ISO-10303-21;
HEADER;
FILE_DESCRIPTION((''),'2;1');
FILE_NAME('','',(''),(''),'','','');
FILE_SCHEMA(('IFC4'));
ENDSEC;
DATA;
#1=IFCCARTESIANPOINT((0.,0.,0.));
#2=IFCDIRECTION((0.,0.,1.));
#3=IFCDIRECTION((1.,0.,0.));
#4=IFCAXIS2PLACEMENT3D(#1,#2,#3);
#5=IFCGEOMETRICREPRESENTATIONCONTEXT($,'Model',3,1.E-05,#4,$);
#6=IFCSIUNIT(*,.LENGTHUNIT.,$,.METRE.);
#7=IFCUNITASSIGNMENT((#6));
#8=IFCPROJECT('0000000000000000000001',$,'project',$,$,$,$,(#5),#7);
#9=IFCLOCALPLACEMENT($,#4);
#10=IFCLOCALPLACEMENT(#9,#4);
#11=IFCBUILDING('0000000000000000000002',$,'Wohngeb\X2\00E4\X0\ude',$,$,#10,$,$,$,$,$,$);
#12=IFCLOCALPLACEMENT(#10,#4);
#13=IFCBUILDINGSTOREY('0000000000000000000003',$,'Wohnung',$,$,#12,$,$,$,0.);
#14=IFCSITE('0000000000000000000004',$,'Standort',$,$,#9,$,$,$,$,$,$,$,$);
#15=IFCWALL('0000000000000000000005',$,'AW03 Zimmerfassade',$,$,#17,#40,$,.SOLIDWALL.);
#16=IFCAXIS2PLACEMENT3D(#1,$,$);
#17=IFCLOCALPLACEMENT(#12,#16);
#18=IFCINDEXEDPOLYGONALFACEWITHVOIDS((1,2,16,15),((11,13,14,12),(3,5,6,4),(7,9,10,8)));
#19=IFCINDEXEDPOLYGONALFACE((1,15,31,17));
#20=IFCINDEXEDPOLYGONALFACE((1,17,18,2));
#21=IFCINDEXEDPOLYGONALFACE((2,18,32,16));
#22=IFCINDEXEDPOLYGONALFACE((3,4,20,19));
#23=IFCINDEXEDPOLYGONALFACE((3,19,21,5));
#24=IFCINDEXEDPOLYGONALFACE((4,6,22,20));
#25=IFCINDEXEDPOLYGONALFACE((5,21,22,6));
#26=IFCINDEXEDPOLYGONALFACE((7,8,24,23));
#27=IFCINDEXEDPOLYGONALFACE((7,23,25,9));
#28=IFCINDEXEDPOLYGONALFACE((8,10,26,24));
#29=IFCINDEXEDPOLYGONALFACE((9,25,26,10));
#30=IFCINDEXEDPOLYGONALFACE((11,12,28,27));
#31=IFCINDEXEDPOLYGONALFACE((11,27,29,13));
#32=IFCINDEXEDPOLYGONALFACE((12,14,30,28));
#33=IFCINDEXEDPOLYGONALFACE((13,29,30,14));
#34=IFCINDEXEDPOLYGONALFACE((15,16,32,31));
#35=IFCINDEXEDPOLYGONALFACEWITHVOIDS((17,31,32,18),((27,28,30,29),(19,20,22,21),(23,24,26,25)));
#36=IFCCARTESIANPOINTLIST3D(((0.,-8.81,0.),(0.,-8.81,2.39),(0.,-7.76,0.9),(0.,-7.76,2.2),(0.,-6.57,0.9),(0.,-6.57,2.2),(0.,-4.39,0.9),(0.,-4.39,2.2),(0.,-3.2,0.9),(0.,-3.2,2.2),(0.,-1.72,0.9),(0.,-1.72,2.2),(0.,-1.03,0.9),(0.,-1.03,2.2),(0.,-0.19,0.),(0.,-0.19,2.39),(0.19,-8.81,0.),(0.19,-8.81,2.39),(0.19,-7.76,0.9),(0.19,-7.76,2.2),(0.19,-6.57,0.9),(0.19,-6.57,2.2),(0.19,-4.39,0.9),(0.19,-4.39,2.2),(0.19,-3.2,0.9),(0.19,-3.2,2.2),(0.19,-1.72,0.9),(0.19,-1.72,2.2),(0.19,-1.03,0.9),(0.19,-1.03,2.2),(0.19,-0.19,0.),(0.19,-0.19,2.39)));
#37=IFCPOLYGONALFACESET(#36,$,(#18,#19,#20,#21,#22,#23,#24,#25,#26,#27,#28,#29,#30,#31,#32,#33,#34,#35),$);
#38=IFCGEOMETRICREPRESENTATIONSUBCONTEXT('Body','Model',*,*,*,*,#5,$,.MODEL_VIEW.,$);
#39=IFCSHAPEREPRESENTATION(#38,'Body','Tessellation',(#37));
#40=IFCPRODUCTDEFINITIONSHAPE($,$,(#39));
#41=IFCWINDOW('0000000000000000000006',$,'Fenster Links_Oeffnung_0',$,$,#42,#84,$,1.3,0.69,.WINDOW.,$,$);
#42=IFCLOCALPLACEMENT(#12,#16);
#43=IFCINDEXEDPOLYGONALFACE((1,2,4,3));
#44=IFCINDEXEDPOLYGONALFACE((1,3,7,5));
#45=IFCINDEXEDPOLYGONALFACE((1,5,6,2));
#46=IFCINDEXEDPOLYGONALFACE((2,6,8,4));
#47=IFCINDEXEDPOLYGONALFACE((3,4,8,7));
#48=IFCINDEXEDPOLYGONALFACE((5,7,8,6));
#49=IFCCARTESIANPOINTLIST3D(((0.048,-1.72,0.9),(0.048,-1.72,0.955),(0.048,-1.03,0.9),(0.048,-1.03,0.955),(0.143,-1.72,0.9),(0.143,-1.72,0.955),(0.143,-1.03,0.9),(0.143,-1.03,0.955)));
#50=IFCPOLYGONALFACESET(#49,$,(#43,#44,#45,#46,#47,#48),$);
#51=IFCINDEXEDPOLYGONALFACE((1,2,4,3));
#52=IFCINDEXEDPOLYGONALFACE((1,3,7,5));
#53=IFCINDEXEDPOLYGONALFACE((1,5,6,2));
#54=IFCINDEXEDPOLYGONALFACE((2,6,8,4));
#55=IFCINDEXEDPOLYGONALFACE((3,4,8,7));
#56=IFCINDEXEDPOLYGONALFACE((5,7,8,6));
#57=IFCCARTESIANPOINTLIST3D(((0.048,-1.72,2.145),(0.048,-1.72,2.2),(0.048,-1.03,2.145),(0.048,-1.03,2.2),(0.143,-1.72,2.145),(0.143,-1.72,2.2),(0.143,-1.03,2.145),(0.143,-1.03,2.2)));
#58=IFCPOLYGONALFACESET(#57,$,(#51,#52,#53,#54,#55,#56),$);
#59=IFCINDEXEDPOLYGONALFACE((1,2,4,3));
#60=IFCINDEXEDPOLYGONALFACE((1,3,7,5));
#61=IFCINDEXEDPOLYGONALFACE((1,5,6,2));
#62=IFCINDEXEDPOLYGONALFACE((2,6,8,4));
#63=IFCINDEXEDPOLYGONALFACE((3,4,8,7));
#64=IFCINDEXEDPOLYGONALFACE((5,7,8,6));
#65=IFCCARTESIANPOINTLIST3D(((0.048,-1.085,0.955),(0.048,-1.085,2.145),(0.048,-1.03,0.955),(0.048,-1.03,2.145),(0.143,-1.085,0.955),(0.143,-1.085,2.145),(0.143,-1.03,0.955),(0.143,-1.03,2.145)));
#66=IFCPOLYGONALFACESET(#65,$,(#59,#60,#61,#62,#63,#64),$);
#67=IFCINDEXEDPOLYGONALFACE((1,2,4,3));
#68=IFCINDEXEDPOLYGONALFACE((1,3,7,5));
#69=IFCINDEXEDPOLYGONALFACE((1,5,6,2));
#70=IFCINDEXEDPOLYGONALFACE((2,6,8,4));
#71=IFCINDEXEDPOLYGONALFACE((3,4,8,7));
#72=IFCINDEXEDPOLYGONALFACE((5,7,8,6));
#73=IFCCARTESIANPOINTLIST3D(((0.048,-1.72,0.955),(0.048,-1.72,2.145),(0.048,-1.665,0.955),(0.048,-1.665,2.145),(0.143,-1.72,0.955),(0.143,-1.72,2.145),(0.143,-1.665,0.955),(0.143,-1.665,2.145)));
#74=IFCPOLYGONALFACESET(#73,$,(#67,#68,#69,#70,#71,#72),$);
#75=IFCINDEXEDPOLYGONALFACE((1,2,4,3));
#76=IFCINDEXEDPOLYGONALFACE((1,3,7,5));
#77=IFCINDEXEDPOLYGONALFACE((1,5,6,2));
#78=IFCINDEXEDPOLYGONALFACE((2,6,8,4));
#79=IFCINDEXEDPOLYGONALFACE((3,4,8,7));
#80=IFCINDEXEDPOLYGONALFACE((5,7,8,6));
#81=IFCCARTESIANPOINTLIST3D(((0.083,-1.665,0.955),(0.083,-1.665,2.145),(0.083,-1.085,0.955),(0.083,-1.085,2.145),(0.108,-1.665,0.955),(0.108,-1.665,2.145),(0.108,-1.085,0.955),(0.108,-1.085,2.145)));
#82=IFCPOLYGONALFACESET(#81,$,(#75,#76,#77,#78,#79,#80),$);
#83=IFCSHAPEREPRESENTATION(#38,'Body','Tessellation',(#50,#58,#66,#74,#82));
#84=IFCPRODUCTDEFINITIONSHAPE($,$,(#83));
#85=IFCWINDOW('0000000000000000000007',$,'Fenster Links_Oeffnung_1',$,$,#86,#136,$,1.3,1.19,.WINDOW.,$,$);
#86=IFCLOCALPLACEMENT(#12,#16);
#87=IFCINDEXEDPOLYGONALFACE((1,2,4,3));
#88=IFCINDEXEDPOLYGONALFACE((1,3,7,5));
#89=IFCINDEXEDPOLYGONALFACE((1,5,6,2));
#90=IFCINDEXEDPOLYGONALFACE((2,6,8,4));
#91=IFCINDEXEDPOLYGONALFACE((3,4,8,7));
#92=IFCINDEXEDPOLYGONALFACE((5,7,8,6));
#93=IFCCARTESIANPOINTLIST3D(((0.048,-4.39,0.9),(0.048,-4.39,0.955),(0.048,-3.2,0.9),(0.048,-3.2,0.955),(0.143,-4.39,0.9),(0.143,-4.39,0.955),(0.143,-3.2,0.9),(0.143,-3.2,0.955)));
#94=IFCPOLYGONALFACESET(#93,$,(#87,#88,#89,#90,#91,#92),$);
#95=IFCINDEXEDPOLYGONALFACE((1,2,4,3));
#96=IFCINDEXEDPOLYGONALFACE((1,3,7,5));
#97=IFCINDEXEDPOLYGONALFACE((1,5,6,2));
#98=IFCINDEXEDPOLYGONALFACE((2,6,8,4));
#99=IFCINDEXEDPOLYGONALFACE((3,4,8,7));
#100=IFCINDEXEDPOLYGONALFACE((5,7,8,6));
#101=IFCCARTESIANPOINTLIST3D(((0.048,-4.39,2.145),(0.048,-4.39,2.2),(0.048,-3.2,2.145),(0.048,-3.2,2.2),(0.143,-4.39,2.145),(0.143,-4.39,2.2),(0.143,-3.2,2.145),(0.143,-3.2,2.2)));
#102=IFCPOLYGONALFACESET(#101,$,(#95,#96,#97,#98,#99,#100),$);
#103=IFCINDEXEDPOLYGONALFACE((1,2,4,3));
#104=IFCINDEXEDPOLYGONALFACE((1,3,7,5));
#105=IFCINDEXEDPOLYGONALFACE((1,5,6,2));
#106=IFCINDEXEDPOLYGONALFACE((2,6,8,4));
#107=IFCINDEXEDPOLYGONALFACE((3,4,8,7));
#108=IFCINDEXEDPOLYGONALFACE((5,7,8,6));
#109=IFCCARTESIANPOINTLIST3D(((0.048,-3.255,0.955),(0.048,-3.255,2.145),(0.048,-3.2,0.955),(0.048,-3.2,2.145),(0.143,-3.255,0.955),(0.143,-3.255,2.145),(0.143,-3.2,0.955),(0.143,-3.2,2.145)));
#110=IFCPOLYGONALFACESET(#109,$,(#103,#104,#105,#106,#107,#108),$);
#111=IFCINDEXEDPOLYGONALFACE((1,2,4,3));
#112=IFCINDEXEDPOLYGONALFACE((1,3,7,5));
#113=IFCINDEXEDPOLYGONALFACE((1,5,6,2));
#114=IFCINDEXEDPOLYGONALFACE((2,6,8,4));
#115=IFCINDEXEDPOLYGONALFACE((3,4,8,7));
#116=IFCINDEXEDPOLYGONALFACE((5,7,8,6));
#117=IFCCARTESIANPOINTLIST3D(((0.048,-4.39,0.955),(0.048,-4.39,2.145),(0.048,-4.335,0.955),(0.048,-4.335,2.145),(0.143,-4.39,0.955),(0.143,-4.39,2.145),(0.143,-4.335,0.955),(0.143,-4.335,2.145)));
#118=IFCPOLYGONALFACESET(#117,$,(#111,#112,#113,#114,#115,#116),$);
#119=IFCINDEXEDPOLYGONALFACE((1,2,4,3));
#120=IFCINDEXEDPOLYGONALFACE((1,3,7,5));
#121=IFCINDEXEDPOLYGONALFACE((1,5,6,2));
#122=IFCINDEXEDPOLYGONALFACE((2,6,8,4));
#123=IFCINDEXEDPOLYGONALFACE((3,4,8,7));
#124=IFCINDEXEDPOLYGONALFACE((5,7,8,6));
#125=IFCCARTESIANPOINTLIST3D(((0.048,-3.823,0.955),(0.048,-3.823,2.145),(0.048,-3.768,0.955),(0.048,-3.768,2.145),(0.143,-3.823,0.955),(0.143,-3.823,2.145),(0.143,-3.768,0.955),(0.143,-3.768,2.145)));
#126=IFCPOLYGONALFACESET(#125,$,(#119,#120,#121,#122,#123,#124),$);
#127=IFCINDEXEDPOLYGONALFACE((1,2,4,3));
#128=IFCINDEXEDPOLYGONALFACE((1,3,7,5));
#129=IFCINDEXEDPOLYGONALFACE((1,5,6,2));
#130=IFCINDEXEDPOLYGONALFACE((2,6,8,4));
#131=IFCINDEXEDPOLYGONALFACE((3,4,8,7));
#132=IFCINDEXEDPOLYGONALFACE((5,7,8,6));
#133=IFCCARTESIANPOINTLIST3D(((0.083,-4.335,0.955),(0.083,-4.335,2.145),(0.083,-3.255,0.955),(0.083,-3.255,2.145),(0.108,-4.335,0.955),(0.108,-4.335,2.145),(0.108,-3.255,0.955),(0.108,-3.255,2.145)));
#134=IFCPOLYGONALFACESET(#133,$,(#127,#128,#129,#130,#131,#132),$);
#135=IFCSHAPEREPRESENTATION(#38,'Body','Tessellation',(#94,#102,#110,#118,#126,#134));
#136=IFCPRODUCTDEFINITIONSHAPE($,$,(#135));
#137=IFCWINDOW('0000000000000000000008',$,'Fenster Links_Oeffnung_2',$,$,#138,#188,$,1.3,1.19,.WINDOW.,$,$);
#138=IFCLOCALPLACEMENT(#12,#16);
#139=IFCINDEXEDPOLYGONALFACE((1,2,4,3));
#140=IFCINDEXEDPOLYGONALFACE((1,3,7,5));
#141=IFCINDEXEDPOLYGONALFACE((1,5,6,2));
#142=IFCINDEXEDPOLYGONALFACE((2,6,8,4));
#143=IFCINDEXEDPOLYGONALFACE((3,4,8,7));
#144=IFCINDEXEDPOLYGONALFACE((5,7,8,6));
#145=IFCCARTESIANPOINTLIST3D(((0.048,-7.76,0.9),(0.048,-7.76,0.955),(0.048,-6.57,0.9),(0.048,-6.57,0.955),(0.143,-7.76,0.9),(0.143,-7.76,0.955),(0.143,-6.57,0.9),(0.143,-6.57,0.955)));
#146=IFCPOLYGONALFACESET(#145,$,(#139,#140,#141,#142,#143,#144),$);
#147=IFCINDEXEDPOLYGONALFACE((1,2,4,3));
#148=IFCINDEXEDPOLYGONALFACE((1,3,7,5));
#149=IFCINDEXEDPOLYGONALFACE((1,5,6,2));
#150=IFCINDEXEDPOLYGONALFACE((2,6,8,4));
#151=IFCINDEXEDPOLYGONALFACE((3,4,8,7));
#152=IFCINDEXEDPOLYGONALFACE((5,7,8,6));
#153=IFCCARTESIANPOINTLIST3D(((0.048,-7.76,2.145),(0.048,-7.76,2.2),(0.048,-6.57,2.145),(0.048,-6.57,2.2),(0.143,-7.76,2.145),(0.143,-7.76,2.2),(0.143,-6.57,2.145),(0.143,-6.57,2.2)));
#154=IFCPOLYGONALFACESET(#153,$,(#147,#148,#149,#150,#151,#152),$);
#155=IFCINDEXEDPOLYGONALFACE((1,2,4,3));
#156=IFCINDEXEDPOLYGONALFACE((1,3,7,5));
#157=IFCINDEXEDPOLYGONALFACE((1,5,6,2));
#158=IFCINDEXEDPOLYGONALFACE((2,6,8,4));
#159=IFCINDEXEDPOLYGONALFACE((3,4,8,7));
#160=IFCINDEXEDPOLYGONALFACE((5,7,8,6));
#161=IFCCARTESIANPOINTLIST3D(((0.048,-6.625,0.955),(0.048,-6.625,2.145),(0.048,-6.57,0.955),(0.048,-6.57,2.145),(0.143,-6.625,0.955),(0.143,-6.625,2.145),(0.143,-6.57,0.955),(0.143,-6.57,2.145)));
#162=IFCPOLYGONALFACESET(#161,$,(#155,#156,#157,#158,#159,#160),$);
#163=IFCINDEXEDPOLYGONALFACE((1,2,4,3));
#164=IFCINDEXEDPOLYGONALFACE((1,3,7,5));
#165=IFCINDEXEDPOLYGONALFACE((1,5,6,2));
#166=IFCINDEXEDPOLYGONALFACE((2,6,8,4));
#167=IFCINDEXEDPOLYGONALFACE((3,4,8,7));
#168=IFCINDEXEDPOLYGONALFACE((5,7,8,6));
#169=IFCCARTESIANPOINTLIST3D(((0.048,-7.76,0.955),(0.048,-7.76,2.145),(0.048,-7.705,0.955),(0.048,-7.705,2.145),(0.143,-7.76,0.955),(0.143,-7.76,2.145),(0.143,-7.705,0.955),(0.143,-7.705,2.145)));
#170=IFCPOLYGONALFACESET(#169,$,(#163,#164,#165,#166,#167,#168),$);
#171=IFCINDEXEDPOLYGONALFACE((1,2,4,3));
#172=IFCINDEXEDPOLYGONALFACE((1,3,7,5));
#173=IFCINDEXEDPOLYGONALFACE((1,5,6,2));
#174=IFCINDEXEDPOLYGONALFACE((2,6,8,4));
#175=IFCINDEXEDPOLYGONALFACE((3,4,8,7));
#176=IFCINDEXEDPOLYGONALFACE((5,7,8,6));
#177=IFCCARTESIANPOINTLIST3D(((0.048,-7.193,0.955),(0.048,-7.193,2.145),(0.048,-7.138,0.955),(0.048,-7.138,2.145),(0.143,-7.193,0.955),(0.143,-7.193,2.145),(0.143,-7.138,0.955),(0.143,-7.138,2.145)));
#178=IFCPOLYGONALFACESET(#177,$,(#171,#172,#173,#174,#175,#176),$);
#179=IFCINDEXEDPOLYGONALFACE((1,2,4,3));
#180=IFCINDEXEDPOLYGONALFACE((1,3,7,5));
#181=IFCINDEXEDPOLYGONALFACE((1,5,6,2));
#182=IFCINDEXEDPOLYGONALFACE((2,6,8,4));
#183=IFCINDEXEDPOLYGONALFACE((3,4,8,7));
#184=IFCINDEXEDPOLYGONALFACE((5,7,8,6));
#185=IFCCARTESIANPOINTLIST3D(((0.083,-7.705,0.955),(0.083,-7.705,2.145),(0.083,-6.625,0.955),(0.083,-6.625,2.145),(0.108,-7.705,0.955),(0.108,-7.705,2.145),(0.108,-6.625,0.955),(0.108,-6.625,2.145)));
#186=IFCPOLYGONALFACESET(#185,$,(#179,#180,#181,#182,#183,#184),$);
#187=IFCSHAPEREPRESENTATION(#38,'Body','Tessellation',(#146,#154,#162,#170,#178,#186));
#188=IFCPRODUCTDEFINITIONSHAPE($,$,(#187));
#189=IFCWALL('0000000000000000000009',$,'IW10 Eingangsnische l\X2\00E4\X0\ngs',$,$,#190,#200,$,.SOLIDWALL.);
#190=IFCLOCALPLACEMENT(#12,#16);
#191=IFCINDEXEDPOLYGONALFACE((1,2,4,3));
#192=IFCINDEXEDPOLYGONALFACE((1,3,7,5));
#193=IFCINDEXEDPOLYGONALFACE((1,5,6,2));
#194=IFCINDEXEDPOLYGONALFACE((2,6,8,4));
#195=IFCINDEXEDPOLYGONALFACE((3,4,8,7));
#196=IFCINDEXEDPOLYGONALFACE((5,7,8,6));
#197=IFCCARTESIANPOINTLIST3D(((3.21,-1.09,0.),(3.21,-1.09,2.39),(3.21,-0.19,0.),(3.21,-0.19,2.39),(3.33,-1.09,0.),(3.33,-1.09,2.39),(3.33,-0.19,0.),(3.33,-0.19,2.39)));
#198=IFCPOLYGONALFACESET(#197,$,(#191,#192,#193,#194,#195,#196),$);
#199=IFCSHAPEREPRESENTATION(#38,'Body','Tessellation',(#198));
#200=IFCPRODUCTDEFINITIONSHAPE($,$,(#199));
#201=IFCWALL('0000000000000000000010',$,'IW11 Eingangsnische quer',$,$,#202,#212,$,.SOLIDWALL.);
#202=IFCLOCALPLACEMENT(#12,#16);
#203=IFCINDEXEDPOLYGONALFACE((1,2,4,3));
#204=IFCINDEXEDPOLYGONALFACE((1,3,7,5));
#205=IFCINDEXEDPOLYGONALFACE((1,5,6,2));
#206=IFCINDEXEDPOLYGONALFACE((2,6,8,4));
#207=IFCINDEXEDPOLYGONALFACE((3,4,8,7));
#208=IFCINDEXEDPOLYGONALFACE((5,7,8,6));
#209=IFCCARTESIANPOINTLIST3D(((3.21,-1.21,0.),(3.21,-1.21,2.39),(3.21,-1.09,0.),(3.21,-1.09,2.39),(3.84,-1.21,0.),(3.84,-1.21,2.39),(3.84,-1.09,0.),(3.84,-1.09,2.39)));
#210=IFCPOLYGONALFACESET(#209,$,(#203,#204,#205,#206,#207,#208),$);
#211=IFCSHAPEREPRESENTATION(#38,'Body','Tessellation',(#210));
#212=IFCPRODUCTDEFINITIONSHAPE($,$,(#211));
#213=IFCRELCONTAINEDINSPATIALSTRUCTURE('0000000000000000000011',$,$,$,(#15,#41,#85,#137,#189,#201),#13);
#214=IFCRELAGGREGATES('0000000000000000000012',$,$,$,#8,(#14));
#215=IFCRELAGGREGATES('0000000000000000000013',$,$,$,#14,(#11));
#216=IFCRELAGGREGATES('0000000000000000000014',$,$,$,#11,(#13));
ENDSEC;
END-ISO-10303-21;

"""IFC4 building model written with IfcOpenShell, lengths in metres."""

from ifc_helpers import new_model, si_unit, frame, origin, origin_with_axes, place, context, subcontext, project, spatial, polyline, outline, extrude, element, fill, save


model = new_model("IFC4")

# Units and contexts
model_context = context("Model", 3, precision=1e-05, world=origin_with_axes())
body_context = subcontext(model_context, "Body", "Model", "MODEL_VIEW")
ifc_project = project(units=[si_unit("LENGTHUNIT", "METRE")], contexts=[model_context])

# Site, building, storey
site_placement = place(None, origin_with_axes())
site = spatial("IfcSite", under=ifc_project, at=site_placement, Name="Standort")
building_placement = place(site_placement, origin_with_axes())
building = spatial("IfcBuilding", under=site, at=building_placement, Name="Wohngebäude")
storey_placement = place(building_placement, origin_with_axes())
storey = spatial("IfcBuildingStorey", under=building, at=storey_placement, Name="Wohnung", Elevation=0.0)

# Wall, openings, windows
wall_1_placement = place(storey_placement, frame((0.0, -0.19, 0.0), z_axis=(0.0, 0.0, 1.0), x_axis=(1.0, 0.0, 0.0)))
wall_1 = element("IfcWall", 1, at=wall_1_placement, inside=storey, Name="AW03 Zimmerfassade", PredefinedType="SOLIDWALL", context=body_context, shape_type="SweptSolid", body=[
    extrude(outline(polyline([(0.0, 0.0), (0.0, -8.62), (0.19, -8.62), (0.19, 0.0), (0.0, 0.0)])), origin(), (0.0, 0.0, 1.0), 2.39),
])
opening_1_placement = place(wall_1_placement, frame((0.0, -0.84, 0.9), z_axis=(0.0, 0.0, 1.0), x_axis=(1.0, 0.0, 0.0)))
opening_1 = element("IfcOpeningElement", 2, at=opening_1_placement, cuts=wall_1, PredefinedType="OPENING", context=body_context, shape_type="SweptSolid", body=[
    extrude(outline(polyline([(-0.005, 0.0), (-0.005, -0.69), (0.195, -0.69), (0.195, 0.0), (-0.005, 0.0)])), origin(), (0.0, 0.0, 1.0), 1.3),
])
opening_2_placement = place(wall_1_placement, frame((0.0, -3.01, 0.9), z_axis=(0.0, 0.0, 1.0), x_axis=(1.0, 0.0, 0.0)))
opening_2 = element("IfcOpeningElement", 3, at=opening_2_placement, cuts=wall_1, PredefinedType="OPENING", context=body_context, shape_type="SweptSolid", body=[
    extrude(outline(polyline([(-0.005, 0.0), (-0.005, -1.19), (0.195, -1.19), (0.195, 0.0), (-0.005, 0.0)])), origin(), (0.0, 0.0, 1.0), 1.3),
])
opening_3_placement = place(wall_1_placement, frame((0.0, -6.38, 0.9), z_axis=(0.0, 0.0, 1.0), x_axis=(1.0, 0.0, 0.0)))
opening_3 = element("IfcOpeningElement", 4, at=opening_3_placement, cuts=wall_1, PredefinedType="OPENING", context=body_context, shape_type="SweptSolid", body=[
    extrude(outline(polyline([(-0.005, 0.0), (-0.005, -1.19), (0.195, -1.19), (0.195, 0.0), (-0.005, 0.0)])), origin(), (0.0, 0.0, 1.0), 1.3),
])
window_1_placement = place(storey_placement, frame((0.0, -1.03, 0.9), z_axis=(0.0, 0.0, 1.0), x_axis=(1.0, 0.0, 0.0)))
window_1 = element("IfcWindow", 5, at=window_1_placement, inside=storey, Name="Fenster Links_Oeffnung_0", OverallHeight=1.3, OverallWidth=0.69, PredefinedType="WINDOW", context=body_context, shape_type="SweptSolid", body=[
    extrude(outline(polyline([(0.048, 0.0), (0.048, -0.69), (0.143, -0.69), (0.143, 0.0), (0.048, 0.0)])), origin(), (0.0, 0.0, 1.0), 0.055),
    extrude(outline(polyline([(0.048, 0.0), (0.048, -0.69), (0.143, -0.69), (0.143, 0.0), (0.048, 0.0)])), frame((0.0, 0.0, 1.245)), (0.0, 0.0, 1.0), 0.055),
    extrude(outline(polyline([(0.048, 0.0), (0.048, -0.055), (0.143, -0.055), (0.143, 0.0), (0.048, 0.0)])), frame((0.0, 0.0, 0.055)), (0.0, 0.0, 1.0), 1.19),
    extrude(outline(polyline([(0.048, -0.635), (0.048, -0.69), (0.143, -0.69), (0.143, -0.635), (0.048, -0.635)])), frame((0.0, 0.0, 0.055)), (0.0, 0.0, 1.0), 1.19),
    extrude(outline(polyline([(0.083, -0.055), (0.083, -0.635), (0.108, -0.635), (0.108, -0.055), (0.083, -0.055)])), frame((0.0, 0.0, 0.055)), (0.0, 0.0, 1.0), 1.19),
])
fill(opening_1, window_1)
window_2_placement = place(storey_placement, frame((0.0, -3.2, 0.9), z_axis=(0.0, 0.0, 1.0), x_axis=(1.0, 0.0, 0.0)))
window_2 = element("IfcWindow", 6, at=window_2_placement, inside=storey, Name="Fenster Links_Oeffnung_1", OverallHeight=1.3, OverallWidth=1.19, PredefinedType="WINDOW", context=body_context, shape_type="SweptSolid", body=[
    extrude(outline(polyline([(0.048, 0.0), (0.048, -1.19), (0.143, -1.19), (0.143, 0.0), (0.048, 0.0)])), origin(), (0.0, 0.0, 1.0), 0.055),
    extrude(outline(polyline([(0.048, 0.0), (0.048, -1.19), (0.143, -1.19), (0.143, 0.0), (0.048, 0.0)])), frame((0.0, 0.0, 1.245)), (0.0, 0.0, 1.0), 0.055),
    extrude(outline(polyline([(0.048, 0.0), (0.048, -0.055), (0.143, -0.055), (0.143, 0.0), (0.048, 0.0)])), frame((0.0, 0.0, 0.055)), (0.0, 0.0, 1.0), 1.19),
    extrude(outline(polyline([(0.048, -1.135), (0.048, -1.19), (0.143, -1.19), (0.143, -1.135), (0.048, -1.135)])), frame((0.0, 0.0, 0.055)), (0.0, 0.0, 1.0), 1.19),
    extrude(outline(polyline([(0.048, -0.568), (0.048, -0.623), (0.143, -0.623), (0.143, -0.568), (0.048, -0.568)])), frame((0.0, 0.0, 0.055)), (0.0, 0.0, 1.0), 1.19),
    extrude(outline(polyline([(0.083, -0.055), (0.083, -1.135), (0.108, -1.135), (0.108, -0.055), (0.083, -0.055)])), frame((0.0, 0.0, 0.055)), (0.0, 0.0, 1.0), 1.19),
])
fill(opening_2, window_2)
window_3_placement = place(storey_placement, frame((0.0, -6.57, 0.9), z_axis=(0.0, 0.0, 1.0), x_axis=(1.0, 0.0, 0.0)))
window_3 = element("IfcWindow", 7, at=window_3_placement, inside=storey, Name="Fenster Links_Oeffnung_2", OverallHeight=1.3, OverallWidth=1.19, PredefinedType="WINDOW", context=body_context, shape_type="SweptSolid", body=[
    extrude(outline(polyline([(0.048, 0.0), (0.048, -1.19), (0.143, -1.19), (0.143, 0.0), (0.048, 0.0)])), origin(), (0.0, 0.0, 1.0), 0.055),
    extrude(outline(polyline([(0.048, 0.0), (0.048, -1.19), (0.143, -1.19), (0.143, 0.0), (0.048, 0.0)])), frame((0.0, 0.0, 1.245)), (0.0, 0.0, 1.0), 0.055),
    extrude(outline(polyline([(0.048, 0.0), (0.048, -0.055), (0.143, -0.055), (0.143, 0.0), (0.048, 0.0)])), frame((0.0, 0.0, 0.055)), (0.0, 0.0, 1.0), 1.19),
    extrude(outline(polyline([(0.048, -1.135), (0.048, -1.19), (0.143, -1.19), (0.143, -1.135), (0.048, -1.135)])), frame((0.0, 0.0, 0.055)), (0.0, 0.0, 1.0), 1.19),
    extrude(outline(polyline([(0.048, -0.568), (0.048, -0.623), (0.143, -0.623), (0.143, -0.568), (0.048, -0.568)])), frame((0.0, 0.0, 0.055)), (0.0, 0.0, 1.0), 1.19),
    extrude(outline(polyline([(0.083, -0.055), (0.083, -1.135), (0.108, -1.135), (0.108, -0.055), (0.083, -0.055)])), frame((0.0, 0.0, 0.055)), (0.0, 0.0, 1.0), 1.19),
])
fill(opening_3, window_3)

# Walls
wall_2_placement = place(storey_placement, frame((3.21, -0.19, 0.0), z_axis=(0.0, 0.0, 1.0), x_axis=(1.0, 0.0, 0.0)))
element("IfcWall", 8, at=wall_2_placement, inside=storey, Name="IW10 Eingangsnische längs", PredefinedType="SOLIDWALL", context=body_context, shape_type="SweptSolid", body=[
    extrude(outline(polyline([(0.0, 0.0), (0.0, -0.9), (0.12, -0.9), (0.12, 0.0), (0.0, 0.0)])), origin(), (0.0, 0.0, 1.0), 2.39),
])
wall_3_placement = place(storey_placement, frame((3.21, -1.09, 0.0), z_axis=(0.0, 0.0, 1.0), x_axis=(1.0, 0.0, 0.0)))
element("IfcWall", 9, at=wall_3_placement, inside=storey, Name="IW11 Eingangsnische quer", PredefinedType="SOLIDWALL", context=body_context, shape_type="SweptSolid", body=[
    extrude(outline(polyline([(0.0, 0.0), (0.0, -0.12), (0.63, -0.12), (0.63, 0.0), (0.0, 0.0)])), origin(), (0.0, 0.0, 1.0), 2.39),
])

save(model, "model.ifc")
